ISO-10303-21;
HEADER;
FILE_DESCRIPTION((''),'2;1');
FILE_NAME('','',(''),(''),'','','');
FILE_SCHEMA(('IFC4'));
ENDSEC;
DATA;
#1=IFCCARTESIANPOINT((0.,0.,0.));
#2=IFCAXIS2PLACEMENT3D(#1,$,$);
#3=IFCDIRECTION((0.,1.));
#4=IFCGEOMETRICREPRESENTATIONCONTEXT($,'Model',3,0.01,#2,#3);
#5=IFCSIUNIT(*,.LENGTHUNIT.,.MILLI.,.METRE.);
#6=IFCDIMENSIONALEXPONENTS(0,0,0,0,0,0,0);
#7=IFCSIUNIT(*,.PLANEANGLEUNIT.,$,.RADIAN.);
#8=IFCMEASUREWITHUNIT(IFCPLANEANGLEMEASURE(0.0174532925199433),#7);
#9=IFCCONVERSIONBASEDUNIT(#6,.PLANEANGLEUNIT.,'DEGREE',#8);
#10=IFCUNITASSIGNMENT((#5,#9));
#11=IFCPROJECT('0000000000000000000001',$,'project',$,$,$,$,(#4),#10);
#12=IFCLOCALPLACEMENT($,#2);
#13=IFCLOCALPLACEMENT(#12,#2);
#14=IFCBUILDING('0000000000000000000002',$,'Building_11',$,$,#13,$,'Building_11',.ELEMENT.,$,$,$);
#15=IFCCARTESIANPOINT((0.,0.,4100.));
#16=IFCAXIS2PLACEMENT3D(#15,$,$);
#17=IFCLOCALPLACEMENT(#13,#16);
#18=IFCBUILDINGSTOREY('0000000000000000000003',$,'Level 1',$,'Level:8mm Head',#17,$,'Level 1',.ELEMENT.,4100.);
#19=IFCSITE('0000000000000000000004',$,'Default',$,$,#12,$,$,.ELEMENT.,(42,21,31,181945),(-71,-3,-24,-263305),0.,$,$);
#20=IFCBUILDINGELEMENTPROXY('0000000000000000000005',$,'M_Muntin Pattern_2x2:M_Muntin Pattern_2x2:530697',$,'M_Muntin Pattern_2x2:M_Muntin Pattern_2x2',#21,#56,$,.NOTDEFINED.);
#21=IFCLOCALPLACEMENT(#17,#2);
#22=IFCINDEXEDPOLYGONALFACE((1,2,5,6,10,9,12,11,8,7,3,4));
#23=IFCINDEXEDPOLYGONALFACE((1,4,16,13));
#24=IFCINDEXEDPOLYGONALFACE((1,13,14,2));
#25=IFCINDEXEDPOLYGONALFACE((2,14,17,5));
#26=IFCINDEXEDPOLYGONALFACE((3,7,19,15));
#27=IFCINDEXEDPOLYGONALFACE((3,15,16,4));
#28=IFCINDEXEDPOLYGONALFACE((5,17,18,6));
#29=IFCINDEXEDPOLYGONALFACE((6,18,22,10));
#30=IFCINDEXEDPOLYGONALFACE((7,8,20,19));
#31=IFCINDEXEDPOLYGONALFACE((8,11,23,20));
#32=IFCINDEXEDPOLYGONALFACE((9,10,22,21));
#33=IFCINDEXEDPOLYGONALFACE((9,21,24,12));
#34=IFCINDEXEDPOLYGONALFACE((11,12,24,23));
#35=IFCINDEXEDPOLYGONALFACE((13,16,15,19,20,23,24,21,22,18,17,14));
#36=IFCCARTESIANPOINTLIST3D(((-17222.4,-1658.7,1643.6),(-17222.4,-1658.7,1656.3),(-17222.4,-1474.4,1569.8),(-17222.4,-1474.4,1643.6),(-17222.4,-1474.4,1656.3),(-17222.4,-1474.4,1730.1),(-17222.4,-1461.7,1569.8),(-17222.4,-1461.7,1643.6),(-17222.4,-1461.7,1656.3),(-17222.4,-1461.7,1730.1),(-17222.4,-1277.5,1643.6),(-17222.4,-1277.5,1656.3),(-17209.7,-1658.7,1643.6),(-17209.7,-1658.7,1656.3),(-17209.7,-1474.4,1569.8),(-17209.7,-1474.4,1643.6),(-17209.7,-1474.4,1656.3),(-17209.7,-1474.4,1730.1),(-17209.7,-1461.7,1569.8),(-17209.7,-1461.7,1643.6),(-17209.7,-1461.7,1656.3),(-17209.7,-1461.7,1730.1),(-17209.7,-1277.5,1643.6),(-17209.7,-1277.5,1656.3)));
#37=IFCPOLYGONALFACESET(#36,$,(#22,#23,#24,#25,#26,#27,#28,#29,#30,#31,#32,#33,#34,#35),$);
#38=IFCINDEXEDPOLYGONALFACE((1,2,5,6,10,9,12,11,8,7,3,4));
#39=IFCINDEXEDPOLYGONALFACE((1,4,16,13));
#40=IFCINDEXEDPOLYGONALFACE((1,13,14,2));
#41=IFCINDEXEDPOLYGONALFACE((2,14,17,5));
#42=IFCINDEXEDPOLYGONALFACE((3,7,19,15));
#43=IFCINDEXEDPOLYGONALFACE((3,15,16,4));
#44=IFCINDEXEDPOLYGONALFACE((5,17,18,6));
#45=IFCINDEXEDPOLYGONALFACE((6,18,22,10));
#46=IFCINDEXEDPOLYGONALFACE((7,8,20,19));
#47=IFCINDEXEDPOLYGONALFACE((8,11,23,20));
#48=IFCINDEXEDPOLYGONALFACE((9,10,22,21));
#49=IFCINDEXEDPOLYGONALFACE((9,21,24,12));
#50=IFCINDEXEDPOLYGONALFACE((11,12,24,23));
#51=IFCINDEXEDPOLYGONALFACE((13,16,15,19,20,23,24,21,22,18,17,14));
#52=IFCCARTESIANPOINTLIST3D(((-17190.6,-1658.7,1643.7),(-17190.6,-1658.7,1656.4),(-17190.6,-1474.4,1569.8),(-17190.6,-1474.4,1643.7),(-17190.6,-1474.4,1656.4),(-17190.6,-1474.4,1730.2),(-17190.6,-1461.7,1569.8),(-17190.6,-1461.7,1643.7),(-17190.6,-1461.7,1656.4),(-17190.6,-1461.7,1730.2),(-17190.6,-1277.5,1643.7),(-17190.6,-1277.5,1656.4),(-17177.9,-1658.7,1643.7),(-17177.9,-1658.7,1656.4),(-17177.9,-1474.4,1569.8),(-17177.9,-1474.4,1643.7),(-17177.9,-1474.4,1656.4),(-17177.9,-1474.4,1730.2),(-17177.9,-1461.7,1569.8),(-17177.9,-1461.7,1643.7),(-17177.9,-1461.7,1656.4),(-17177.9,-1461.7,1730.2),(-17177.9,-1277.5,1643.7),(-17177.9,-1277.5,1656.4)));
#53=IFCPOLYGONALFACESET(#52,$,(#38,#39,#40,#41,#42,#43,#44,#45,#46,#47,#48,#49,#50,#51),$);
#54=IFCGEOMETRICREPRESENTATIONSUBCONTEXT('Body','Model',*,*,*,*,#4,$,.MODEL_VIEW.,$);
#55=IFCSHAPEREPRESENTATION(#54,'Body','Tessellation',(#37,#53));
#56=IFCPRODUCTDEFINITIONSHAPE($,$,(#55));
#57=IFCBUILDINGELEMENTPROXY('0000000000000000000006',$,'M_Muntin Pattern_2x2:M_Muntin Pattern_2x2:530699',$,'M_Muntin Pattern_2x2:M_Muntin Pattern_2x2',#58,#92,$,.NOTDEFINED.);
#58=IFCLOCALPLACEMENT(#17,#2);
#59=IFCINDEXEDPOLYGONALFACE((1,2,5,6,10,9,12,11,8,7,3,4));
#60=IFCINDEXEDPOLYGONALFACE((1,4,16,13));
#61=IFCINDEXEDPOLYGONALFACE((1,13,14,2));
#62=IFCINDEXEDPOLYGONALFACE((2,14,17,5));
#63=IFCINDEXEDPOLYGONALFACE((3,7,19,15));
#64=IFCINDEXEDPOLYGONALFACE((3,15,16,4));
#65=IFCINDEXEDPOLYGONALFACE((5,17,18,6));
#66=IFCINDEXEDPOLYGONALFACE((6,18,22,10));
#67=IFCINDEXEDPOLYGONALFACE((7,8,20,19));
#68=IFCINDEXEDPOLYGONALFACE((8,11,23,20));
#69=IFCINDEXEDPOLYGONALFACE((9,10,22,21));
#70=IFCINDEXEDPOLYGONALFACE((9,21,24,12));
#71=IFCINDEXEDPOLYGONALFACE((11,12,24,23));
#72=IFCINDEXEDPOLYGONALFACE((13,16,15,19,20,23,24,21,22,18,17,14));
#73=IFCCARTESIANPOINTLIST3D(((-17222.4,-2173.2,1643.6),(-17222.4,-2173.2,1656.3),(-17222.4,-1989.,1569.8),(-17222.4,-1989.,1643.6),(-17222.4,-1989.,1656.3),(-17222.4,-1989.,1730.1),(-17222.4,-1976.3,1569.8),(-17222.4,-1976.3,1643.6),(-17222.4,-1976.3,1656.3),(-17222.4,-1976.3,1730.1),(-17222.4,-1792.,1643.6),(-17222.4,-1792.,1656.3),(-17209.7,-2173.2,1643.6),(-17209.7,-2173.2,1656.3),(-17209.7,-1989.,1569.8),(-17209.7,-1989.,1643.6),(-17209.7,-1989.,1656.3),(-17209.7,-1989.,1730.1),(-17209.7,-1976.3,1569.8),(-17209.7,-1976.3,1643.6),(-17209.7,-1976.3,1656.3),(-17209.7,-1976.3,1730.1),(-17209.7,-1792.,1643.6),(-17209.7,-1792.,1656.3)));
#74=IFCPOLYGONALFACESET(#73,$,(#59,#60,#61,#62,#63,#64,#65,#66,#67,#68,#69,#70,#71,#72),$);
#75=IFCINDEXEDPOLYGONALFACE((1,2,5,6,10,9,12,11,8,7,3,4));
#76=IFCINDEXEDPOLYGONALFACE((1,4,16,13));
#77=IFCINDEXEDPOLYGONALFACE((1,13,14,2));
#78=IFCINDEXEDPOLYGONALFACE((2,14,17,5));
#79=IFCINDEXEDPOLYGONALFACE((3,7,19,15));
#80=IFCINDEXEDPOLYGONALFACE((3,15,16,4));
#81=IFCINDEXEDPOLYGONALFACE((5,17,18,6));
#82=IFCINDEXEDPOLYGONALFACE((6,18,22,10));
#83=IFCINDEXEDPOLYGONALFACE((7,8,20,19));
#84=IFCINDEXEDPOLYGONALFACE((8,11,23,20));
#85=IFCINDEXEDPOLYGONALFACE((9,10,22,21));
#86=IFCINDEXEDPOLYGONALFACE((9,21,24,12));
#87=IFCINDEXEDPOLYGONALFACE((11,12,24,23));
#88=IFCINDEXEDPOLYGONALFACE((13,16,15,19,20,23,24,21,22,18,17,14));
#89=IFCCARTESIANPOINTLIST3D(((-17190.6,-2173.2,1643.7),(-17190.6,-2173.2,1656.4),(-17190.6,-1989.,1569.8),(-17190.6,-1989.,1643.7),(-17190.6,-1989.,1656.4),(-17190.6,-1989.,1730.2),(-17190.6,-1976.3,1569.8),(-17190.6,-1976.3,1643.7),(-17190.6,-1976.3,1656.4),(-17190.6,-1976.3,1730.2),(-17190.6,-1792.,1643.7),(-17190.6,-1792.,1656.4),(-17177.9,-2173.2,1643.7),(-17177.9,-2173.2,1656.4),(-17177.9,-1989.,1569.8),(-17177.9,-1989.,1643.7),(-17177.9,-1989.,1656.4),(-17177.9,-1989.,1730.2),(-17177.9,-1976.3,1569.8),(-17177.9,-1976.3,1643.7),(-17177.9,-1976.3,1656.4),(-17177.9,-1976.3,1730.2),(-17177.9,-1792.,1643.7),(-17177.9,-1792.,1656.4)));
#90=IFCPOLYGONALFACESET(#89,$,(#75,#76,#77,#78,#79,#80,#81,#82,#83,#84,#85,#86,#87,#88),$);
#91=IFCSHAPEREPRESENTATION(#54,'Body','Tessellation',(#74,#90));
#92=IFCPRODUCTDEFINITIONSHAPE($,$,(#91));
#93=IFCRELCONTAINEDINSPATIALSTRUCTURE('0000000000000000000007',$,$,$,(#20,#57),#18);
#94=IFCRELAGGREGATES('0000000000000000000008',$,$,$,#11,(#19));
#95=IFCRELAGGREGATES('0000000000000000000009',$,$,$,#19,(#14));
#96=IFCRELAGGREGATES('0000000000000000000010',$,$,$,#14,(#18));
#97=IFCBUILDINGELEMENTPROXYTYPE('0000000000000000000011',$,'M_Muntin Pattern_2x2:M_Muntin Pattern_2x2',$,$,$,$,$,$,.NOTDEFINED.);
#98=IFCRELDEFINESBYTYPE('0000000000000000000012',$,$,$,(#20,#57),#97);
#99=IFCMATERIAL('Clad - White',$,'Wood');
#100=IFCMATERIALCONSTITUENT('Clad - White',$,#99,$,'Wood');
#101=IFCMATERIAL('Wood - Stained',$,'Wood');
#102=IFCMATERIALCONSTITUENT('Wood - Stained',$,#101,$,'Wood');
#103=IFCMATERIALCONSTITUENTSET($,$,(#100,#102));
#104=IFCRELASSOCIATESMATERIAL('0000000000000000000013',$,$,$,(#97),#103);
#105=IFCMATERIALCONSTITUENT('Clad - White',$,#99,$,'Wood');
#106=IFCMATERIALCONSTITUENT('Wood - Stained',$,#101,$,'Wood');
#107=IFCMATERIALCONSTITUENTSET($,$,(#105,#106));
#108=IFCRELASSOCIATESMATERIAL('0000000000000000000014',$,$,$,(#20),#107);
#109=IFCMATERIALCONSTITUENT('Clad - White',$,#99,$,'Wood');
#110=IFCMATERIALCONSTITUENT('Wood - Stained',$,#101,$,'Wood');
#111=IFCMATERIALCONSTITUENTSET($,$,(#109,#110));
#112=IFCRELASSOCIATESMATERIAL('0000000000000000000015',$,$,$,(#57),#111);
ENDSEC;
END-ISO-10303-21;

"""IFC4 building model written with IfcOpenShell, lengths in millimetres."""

from ifc_helpers import new_model, entity, si_unit, converted_unit, direction, frame, origin, place, context, subcontext, project, spatial, indexed_curve, outline, extrude, source, transform, mapped, material, constituent, constituent_set, type_object, type_shapes, element, save


model = new_model("IFC4")

# Units and contexts
model_context = context("Model", 3, precision=0.01, world=origin(), true_north=direction((0.0, 1.0)))
body_context = subcontext(model_context, "Body", "Model", "MODEL_VIEW")
ifc_project = project(units=[si_unit("LENGTHUNIT", "METRE", prefix="MILLI"), converted_unit("PLANEANGLEUNIT", "DEGREE", entity("IfcPlaneAngleMeasure", 0.0174532925199433), si_unit("PLANEANGLEUNIT", "RADIAN"), dimensions=[0, 0, 0, 0, 0, 0, 0])], contexts=[model_context])

# Site, building, storey
site_placement = place(None, origin())
site = spatial("IfcSite", under=ifc_project, at=site_placement, Name="Default", CompositionType="ELEMENT", RefLatitude=(42, 21, 31, 181945), RefLongitude=(-71, -3, -24, -263305), RefElevation=0.0)
building_placement = place(site_placement, origin())
building = spatial("IfcBuilding", under=site, at=building_placement, Name="Building_11", LongName="Building_11", CompositionType="ELEMENT")
storey_placement = place(building_placement, frame((0.0, 0.0, 4100.0)))
storey = spatial("IfcBuildingStorey", under=building, at=storey_placement, Name="Level 1", ObjectType="Level:8mm Head", LongName="Level 1", CompositionType="ELEMENT", Elevation=4100.0)

# Building element proxies
ifc_material_1 = material(Name="Clad - White", Category="Wood")
ifc_material_2 = material(Name="Wood - Stained", Category="Wood")
ifc_constituent_1 = constituent(ifc_material_1, Name="Clad - White", Category="Wood")
ifc_constituent_2 = constituent(ifc_material_2, Name="Wood - Stained", Category="Wood")
ifc_constituent_set_1 = constituent_set(constituents=[ifc_constituent_1, ifc_constituent_2])
building_element_proxy_type_1 = type_object("IfcBuildingElementProxyType", Name="M_Muntin Pattern_2x2:M_Muntin Pattern_2x2", PredefinedType="NOTDEFINED", material=ifc_constituent_set_1)
shared_shape_1 = source(origin(), body_context, "Body", "SweptSolid", [
    extrude(outline(indexed_curve([(6.4, -6.4), (80.1, -6.4), (80.1, 6.3), (6.4, 6.3), (6.4, 190.6), (-6.3, 190.6), (-6.3, 6.3), (-80.2, 6.3), (-80.2, -6.4), (-6.3, -6.4), (-6.3, -190.6), (6.4, -190.6), (6.4, -6.4)], self_intersect=False)), frame((0.0, 9.5, 80.1), z_axis=(0.0, 1.0, 0.0), x_axis=(0.0, 0.0, 1.0)), (0.0, 0.0, 1.0), 12.7),
    extrude(outline(indexed_curve([(6.4, -6.4), (80.2, -6.4), (80.2, 6.3), (6.4, 6.3), (6.4, 190.6), (-6.3, 190.6), (-6.3, 6.3), (-80.2, 6.3), (-80.2, -6.4), (-6.3, -6.4), (-6.3, -190.6), (6.4, -190.6), (6.4, -6.4)], self_intersect=False)), frame((0.0, -22.2, 80.2), z_axis=(0.0, 1.0, 0.0), x_axis=(0.0, 0.0, 1.0)), (0.0, 0.0, 1.0), 12.7),
])
type_shapes(building_element_proxy_type_1, [shared_shape_1])
ifc_constituent_3 = constituent(ifc_material_1, Name="Clad - White", Category="Wood")
ifc_constituent_4 = constituent(ifc_material_2, Name="Wood - Stained", Category="Wood")
ifc_constituent_set_2 = constituent_set(constituents=[ifc_constituent_3, ifc_constituent_4])
proxy_1_placement = place(storey_placement, frame((-17200.2, -1468.1, 1569.8), z_axis=(0.0, 0.0, 1.0), x_axis=(0.0, 1.0, 0.0)))
element("IfcBuildingElementProxy", 1, at=proxy_1_placement, inside=storey, type_object=building_element_proxy_type_1, material=ifc_constituent_set_2, Name="M_Muntin Pattern_2x2:M_Muntin Pattern_2x2:530697", ObjectType="M_Muntin Pattern_2x2:M_Muntin Pattern_2x2", PredefinedType="NOTDEFINED", context=body_context, shape_type="MappedRepresentation", body=[
    mapped(shared_shape_1, transform((0.0, 0.0, 0.0), scale=1.0)),
])
ifc_constituent_5 = constituent(ifc_material_1, Name="Clad - White", Category="Wood")
ifc_constituent_6 = constituent(ifc_material_2, Name="Wood - Stained", Category="Wood")
ifc_constituent_set_3 = constituent_set(constituents=[ifc_constituent_5, ifc_constituent_6])
proxy_2_placement = place(storey_placement, frame((-17200.2, -1982.6, 1569.8), z_axis=(0.0, 0.0, 1.0), x_axis=(0.0, 1.0, 0.0)))
element("IfcBuildingElementProxy", 2, at=proxy_2_placement, inside=storey, type_object=building_element_proxy_type_1, material=ifc_constituent_set_3, Name="M_Muntin Pattern_2x2:M_Muntin Pattern_2x2:530699", ObjectType="M_Muntin Pattern_2x2:M_Muntin Pattern_2x2", PredefinedType="NOTDEFINED", context=body_context, shape_type="MappedRepresentation", body=[
    mapped(shared_shape_1, transform((0.0, 0.0, 0.0), scale=1.0)),
])

save(model, "model.ifc")
